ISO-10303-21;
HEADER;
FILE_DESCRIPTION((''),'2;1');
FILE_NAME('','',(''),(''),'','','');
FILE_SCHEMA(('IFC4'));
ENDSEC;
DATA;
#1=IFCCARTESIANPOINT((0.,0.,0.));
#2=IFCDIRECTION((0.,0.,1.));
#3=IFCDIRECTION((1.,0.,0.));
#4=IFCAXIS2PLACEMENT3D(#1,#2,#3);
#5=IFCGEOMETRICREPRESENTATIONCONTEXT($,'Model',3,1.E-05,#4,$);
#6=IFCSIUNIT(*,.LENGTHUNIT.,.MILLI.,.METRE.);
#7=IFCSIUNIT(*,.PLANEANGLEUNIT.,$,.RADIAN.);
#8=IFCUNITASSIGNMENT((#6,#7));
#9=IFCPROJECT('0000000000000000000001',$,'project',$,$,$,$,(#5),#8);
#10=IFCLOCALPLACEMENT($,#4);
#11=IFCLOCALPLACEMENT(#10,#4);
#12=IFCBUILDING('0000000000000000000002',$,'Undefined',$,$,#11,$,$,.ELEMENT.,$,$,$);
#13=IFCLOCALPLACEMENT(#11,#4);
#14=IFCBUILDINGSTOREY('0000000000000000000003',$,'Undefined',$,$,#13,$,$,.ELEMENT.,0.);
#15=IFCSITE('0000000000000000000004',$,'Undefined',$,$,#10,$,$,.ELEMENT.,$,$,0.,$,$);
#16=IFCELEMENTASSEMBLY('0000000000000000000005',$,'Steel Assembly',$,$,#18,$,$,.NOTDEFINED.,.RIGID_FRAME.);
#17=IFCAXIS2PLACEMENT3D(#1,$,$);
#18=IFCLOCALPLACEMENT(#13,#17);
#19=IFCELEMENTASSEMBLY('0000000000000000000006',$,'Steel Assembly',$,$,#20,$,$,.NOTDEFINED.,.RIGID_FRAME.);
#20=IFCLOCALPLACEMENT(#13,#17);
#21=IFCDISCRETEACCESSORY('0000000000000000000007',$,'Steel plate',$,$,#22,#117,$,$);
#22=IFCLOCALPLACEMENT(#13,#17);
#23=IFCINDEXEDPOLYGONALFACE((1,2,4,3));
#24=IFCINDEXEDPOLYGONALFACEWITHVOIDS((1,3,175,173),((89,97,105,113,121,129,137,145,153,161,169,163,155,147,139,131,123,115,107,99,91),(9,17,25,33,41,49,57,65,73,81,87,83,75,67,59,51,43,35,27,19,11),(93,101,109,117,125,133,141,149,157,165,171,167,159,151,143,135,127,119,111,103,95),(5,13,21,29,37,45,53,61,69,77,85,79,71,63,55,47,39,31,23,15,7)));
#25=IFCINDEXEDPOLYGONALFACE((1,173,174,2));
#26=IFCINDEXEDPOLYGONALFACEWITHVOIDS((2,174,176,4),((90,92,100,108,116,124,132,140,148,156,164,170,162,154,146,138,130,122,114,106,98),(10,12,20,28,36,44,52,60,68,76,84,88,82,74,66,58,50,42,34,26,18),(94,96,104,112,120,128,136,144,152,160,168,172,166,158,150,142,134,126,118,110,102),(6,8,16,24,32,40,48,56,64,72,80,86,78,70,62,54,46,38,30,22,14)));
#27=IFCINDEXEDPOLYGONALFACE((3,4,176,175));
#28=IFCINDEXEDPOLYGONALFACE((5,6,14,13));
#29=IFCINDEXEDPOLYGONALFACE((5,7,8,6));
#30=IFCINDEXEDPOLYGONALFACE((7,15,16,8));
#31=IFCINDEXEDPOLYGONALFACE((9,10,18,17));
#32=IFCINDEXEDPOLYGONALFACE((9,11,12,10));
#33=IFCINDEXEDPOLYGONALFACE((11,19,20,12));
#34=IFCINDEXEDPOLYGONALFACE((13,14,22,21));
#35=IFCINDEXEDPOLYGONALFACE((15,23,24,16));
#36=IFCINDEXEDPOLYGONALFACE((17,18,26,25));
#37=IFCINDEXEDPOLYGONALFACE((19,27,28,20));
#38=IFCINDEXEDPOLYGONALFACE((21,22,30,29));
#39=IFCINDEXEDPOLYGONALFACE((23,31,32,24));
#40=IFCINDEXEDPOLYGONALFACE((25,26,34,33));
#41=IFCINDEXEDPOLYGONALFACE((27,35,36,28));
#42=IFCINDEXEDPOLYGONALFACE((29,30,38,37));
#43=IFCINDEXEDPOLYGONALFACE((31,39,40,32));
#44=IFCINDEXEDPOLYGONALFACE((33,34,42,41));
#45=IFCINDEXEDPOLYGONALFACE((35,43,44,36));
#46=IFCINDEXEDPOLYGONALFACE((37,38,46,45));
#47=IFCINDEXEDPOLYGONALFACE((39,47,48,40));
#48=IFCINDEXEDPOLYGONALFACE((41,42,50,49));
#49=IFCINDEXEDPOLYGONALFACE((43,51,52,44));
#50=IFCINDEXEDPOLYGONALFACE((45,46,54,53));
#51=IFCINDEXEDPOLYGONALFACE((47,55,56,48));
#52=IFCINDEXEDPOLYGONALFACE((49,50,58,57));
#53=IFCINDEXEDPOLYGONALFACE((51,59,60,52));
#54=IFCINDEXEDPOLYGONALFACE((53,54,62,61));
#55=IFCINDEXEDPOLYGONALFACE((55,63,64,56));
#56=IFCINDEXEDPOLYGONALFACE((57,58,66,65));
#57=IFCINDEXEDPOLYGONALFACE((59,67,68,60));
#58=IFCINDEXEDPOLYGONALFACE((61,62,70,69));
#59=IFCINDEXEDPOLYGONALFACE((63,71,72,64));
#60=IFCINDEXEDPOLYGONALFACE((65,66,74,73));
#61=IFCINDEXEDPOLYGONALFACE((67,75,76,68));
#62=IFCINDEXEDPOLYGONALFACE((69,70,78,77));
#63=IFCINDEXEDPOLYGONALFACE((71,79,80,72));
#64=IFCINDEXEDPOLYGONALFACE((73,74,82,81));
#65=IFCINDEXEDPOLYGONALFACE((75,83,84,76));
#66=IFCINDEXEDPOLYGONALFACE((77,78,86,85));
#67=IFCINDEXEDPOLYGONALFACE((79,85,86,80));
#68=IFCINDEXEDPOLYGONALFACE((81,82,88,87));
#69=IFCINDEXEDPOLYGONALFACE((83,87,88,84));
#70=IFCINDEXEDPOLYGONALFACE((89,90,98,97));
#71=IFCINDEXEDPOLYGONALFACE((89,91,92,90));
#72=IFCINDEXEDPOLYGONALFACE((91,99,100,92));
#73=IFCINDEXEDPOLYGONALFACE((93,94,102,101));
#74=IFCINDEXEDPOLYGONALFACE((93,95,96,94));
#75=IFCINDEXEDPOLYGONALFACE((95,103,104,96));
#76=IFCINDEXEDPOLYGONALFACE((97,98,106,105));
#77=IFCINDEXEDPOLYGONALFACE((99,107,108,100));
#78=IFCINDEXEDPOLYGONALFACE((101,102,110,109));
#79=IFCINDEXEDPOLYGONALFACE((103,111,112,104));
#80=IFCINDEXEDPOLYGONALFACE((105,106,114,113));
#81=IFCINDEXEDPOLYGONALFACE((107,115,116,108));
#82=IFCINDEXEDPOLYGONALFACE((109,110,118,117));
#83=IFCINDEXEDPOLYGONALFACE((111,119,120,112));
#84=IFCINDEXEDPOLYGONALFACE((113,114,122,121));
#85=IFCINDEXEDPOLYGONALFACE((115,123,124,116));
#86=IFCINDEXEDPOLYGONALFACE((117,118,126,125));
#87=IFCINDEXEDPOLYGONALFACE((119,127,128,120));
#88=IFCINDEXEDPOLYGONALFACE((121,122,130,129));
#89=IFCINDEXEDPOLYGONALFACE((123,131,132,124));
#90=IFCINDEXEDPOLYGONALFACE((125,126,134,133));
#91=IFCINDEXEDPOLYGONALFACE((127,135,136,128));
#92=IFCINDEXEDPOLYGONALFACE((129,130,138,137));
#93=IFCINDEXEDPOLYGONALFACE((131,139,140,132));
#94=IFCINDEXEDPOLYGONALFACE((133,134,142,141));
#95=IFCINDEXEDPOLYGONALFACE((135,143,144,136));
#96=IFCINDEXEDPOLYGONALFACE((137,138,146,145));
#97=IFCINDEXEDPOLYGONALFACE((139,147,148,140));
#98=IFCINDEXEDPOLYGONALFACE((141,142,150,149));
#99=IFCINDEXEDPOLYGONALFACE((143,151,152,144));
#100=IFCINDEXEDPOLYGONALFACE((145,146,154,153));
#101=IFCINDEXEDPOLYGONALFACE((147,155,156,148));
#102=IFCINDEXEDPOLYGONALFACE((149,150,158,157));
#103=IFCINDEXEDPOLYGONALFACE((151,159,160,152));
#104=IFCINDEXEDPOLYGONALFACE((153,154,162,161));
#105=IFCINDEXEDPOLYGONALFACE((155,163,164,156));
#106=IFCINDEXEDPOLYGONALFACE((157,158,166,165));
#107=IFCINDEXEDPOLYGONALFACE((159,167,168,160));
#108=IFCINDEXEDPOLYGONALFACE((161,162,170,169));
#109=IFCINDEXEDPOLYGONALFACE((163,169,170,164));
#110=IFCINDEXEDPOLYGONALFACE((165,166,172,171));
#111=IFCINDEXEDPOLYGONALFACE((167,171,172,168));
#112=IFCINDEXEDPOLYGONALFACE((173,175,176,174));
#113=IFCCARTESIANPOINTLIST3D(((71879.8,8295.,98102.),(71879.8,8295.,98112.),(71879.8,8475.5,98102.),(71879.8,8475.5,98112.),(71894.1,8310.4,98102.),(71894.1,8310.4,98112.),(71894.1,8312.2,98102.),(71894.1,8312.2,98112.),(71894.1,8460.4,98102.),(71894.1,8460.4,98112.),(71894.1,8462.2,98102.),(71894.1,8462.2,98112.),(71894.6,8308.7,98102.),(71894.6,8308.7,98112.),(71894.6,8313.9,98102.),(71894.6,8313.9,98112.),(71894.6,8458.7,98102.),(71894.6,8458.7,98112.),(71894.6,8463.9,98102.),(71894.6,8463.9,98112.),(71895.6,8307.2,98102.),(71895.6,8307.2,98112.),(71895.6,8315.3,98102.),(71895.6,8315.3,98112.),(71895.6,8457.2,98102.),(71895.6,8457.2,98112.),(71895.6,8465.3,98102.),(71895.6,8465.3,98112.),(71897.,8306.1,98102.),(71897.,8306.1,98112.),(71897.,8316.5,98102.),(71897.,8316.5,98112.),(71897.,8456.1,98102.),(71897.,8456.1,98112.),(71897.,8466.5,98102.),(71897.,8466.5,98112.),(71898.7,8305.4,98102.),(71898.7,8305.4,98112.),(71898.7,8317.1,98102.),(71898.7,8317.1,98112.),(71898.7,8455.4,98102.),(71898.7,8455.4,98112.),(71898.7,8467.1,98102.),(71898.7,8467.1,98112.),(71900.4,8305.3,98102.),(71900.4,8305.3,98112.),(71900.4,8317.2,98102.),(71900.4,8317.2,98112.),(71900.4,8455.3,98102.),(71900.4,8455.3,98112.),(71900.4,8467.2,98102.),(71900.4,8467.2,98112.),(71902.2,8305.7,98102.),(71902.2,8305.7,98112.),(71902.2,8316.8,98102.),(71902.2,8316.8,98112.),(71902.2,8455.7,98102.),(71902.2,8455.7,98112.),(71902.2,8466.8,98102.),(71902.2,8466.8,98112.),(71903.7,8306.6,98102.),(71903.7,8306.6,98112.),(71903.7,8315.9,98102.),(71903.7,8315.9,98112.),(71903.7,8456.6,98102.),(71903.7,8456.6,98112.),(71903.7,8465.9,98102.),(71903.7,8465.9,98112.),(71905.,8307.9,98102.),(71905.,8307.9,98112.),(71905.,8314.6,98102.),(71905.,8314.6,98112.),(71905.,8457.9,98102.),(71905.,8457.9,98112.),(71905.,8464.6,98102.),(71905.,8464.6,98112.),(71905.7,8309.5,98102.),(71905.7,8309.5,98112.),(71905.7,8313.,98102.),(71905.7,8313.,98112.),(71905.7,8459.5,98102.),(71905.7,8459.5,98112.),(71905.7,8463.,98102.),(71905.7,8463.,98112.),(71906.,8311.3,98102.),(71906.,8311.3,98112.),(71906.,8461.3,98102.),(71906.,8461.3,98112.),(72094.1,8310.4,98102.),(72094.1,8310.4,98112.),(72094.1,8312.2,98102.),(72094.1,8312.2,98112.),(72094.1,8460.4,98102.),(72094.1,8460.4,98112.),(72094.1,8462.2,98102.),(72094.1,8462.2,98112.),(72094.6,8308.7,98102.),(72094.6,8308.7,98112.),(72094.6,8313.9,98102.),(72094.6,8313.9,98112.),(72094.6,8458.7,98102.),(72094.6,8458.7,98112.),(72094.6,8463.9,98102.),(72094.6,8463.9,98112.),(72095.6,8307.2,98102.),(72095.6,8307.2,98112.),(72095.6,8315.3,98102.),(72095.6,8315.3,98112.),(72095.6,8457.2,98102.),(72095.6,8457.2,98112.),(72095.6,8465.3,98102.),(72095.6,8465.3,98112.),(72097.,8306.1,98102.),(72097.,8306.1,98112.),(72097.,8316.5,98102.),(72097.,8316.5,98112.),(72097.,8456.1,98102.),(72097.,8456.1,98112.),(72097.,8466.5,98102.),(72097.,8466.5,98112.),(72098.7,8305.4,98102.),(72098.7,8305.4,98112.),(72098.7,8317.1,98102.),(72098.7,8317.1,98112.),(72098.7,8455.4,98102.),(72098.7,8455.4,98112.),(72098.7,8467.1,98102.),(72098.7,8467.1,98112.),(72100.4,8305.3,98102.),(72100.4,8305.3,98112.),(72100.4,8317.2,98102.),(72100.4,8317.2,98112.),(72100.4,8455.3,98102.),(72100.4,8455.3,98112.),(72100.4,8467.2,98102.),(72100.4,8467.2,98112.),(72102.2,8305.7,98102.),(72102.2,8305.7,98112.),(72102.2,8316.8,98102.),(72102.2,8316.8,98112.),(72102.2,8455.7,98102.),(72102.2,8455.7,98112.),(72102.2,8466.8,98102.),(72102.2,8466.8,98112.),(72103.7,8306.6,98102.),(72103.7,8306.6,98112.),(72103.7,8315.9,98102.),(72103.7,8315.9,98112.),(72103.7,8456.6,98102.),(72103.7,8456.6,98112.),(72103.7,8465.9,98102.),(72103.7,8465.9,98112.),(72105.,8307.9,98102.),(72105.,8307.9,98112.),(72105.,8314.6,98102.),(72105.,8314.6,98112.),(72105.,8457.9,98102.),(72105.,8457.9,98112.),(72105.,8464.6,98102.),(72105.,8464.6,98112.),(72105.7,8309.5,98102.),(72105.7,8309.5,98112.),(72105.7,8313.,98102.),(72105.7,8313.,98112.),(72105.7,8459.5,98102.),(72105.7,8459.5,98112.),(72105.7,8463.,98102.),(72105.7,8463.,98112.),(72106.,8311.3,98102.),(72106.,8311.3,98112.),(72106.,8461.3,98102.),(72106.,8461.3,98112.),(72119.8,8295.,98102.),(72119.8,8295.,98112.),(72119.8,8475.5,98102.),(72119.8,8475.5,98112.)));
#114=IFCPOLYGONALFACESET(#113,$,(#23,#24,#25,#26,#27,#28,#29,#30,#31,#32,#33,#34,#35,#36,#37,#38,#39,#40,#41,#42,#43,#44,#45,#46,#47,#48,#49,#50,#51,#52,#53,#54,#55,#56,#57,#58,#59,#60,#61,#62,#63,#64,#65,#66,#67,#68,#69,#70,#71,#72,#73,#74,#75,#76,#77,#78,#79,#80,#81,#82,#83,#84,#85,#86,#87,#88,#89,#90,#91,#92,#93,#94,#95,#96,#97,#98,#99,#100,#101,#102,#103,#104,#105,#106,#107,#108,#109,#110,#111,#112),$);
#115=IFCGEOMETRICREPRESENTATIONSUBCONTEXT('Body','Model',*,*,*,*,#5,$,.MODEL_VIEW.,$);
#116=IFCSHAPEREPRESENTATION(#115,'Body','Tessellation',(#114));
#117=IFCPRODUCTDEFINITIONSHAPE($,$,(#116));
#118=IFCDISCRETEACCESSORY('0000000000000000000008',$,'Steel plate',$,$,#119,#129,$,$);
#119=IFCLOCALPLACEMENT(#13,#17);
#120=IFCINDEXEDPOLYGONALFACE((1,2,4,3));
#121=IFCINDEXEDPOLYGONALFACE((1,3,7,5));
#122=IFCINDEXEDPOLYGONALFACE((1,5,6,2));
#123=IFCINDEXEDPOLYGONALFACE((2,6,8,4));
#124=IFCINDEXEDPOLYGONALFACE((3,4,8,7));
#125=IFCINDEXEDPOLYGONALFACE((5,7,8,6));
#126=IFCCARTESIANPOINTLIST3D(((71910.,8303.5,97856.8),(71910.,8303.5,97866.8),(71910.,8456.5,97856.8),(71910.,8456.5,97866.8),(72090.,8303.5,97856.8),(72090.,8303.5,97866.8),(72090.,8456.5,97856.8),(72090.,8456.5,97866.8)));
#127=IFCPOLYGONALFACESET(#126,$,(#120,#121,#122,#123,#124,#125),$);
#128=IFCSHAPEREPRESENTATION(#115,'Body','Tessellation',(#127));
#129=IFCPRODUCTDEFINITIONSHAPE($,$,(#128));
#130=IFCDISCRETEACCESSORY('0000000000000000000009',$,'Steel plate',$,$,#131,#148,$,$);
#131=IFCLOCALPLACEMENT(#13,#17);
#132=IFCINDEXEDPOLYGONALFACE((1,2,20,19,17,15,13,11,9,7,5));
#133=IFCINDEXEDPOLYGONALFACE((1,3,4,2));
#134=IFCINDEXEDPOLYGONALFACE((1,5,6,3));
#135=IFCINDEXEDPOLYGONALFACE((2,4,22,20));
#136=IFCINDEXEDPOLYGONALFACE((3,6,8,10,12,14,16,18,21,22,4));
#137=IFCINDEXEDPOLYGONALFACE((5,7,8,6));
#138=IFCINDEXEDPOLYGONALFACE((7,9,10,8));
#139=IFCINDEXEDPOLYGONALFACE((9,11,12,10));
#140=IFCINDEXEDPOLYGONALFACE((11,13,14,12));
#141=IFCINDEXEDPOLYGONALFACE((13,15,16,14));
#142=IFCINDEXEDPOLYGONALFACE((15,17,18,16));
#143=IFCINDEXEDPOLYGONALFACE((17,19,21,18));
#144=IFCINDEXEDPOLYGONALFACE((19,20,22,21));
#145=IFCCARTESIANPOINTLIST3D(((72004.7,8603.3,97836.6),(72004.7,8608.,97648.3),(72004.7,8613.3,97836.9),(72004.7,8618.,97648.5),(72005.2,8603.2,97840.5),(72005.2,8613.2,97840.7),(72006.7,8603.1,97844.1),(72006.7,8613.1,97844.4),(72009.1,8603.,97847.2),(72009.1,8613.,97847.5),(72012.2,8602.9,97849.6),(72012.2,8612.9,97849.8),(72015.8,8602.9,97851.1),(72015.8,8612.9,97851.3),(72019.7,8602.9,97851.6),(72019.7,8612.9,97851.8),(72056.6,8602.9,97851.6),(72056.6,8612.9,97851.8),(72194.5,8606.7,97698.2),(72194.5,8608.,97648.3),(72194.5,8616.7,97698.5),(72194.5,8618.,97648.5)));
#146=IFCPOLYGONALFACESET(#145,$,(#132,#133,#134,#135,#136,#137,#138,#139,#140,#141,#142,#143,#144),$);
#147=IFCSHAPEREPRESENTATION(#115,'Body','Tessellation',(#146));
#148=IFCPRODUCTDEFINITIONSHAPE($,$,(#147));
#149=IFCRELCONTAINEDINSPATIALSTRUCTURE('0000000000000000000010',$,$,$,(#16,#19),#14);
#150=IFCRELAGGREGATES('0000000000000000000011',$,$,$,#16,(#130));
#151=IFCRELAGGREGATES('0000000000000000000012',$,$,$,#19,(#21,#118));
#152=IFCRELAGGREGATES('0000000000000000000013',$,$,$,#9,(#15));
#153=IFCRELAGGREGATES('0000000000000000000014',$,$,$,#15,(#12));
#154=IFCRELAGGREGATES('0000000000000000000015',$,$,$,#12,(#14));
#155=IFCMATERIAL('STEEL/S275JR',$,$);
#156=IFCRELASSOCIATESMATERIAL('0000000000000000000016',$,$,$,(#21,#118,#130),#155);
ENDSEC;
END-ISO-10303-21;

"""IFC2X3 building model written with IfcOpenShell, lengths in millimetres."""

from ifc_helpers import new_model, si_unit, frame, frame_2d, origin_with_axes, origin_2d_with_axis, place, context, subcontext, project, spatial, polyline, circle_curve, parameter, trimmed, segment, composite_curve, circle, outline, extrude, source, transform, mapped, material, element, aggregate, save


model = new_model("IFC2X3")

# Units and contexts
model_context = context("Model", 3, precision=1e-05, world=origin_with_axes())
body_context = subcontext(model_context, "Body", "Model", "MODEL_VIEW")
ifc_project = project(units=[si_unit("LENGTHUNIT", "METRE", prefix="MILLI"), si_unit("PLANEANGLEUNIT", "RADIAN")], contexts=[model_context])

# Site, building, storey
site_placement = place(None, origin_with_axes())
site = spatial("IfcSite", under=ifc_project, at=site_placement, Name="Undefined", CompositionType="ELEMENT", RefElevation=0.0)
building_placement = place(site_placement, origin_with_axes())
building = spatial("IfcBuilding", under=site, at=building_placement, Name="Undefined", CompositionType="ELEMENT")
storey_placement = place(building_placement, origin_with_axes())
storey = spatial("IfcBuildingStorey", under=building, at=storey_placement, Name="Undefined", CompositionType="ELEMENT", Elevation=0.0)

# Shared definitions
ifc_material_1 = material(Name="STEEL/S275JR")

# Element assembly
assembly_1_placement = place(storey_placement, origin_with_axes())
assembly_1 = element("IfcElementAssembly", 1, at=assembly_1_placement, inside=storey, Name="Steel Assembly", AssemblyPlace="NOTDEFINED", PredefinedType="RIGID_FRAME")

# Element assembly, discrete accessories, opening
assembly_2_placement = place(storey_placement, origin_with_axes())
assembly_2 = element("IfcElementAssembly", 2, at=assembly_2_placement, inside=storey, Name="Steel Assembly", AssemblyPlace="NOTDEFINED", PredefinedType="RIGID_FRAME")
discrete_accessory_1_placement = place(assembly_2_placement, frame((72119.8, 8475.5, 98107.0), z_axis=(0.0, 0.0, 1.0), x_axis=(-1.0, 0.0, 0.0)))
discrete_accessory_1 = element("IfcDiscreteAccessory", 3, at=discrete_accessory_1_placement, material=ifc_material_1, Name="Steel plate", context=body_context, shape_type="SweptSolid", body=[
    extrude(outline(polyline([(0.0, 0.0), (240.0, 0.0), (240.0, 180.5), (0.0, 180.5), (0.0, 0.0)])), frame((0.0, 0.0, -5.0), z_axis=(0.0, 0.0, 1.0), x_axis=(1.0, 0.0, 0.0)), (0.0, 0.0, 1.0), 10.0),
])
shared_shape_1 = source(origin_with_axes(), body_context, "Body", "SweptSolid", [
    extrude(circle(Radius=6.0, at=origin_2d_with_axis()), frame((0.0, -0.1, 0.0), z_axis=(0.0, 1.0, 0.0), x_axis=(1.0, 0.0, 0.0)), (0.0, 0.0, 1.0), 10.2),
])
opening_1_placement = place(assembly_2_placement, frame((71900.0, 8386.3, 98112.0), z_axis=(0.0, 1.0, -0.000001), x_axis=(1.0, 0.0, 0.0)))
element("IfcOpeningElement", 4, at=opening_1_placement, cuts=discrete_accessory_1, ObjectType="Opening", context=body_context, shape_type="MappedRepresentation", body=[
    mapped(shared_shape_1, transform((0.0, 0.0, -75.0))),
    mapped(shared_shape_1, transform((200.0, 0.0, -75.0))),
    mapped(shared_shape_1, transform((0.0, 0.0, 75.0))),
    mapped(shared_shape_1, transform((200.0, 0.0, 75.0))),
])
discrete_accessory_2_placement = place(assembly_2_placement, frame((72090.0, 8456.5, 97861.8), z_axis=(0.0, 0.0, 1.0), x_axis=(-1.0, 0.0, 0.0)))
discrete_accessory_2 = element("IfcDiscreteAccessory", 5, at=discrete_accessory_2_placement, material=ifc_material_1, Name="Steel plate", context=body_context, shape_type="SweptSolid", body=[
    extrude(outline(polyline([(0.0, 0.0), (180.0, 0.0), (180.0, 153.0), (0.0, 153.0), (0.0, 0.0)])), frame((0.0, 0.0, -5.0), z_axis=(0.0, 0.0, 1.0), x_axis=(1.0, 0.0, 0.0)), (0.0, 0.0, 1.0), 10.0),
])

# Discrete accessory
discrete_accessory_3_placement = place(assembly_1_placement, frame((72004.7, 8607.9, 97851.7), z_axis=(0.0, 0.999688, 0.024983), x_axis=(1.0, 0.0, 0.0)))
discrete_accessory_3 = element("IfcDiscreteAccessory", 6, at=discrete_accessory_3_placement, material=ifc_material_1, Name="Steel plate", context=body_context, shape_type="SweptSolid", body=[
    extrude(outline(composite_curve([segment(trimmed(circle_curve(frame_2d((15.0, 15.0), x_axis=(-1.0, 0.0)), 15.0), [parameter(0.0)], [parameter(1.570796)], True, "PARAMETER"), True, "CONTINUOUS"), segment(polyline([(15.0, 0.0), (51.9, 0.0), (189.8, 153.4), (189.8, 203.4), (0.0, 203.4), (0.0, 15.0)]), True, "DISCONTINUOUS")], self_intersect=False)), frame((0.0, 0.0, -5.0), z_axis=(0.0, 0.0, 1.0), x_axis=(1.0, 0.0, 0.0)), (0.0, 0.0, 1.0), 10.0),
])
aggregate(assembly_1, [discrete_accessory_3])

aggregate(assembly_2, [discrete_accessory_1, discrete_accessory_2])

save(model, "model.ifc")
